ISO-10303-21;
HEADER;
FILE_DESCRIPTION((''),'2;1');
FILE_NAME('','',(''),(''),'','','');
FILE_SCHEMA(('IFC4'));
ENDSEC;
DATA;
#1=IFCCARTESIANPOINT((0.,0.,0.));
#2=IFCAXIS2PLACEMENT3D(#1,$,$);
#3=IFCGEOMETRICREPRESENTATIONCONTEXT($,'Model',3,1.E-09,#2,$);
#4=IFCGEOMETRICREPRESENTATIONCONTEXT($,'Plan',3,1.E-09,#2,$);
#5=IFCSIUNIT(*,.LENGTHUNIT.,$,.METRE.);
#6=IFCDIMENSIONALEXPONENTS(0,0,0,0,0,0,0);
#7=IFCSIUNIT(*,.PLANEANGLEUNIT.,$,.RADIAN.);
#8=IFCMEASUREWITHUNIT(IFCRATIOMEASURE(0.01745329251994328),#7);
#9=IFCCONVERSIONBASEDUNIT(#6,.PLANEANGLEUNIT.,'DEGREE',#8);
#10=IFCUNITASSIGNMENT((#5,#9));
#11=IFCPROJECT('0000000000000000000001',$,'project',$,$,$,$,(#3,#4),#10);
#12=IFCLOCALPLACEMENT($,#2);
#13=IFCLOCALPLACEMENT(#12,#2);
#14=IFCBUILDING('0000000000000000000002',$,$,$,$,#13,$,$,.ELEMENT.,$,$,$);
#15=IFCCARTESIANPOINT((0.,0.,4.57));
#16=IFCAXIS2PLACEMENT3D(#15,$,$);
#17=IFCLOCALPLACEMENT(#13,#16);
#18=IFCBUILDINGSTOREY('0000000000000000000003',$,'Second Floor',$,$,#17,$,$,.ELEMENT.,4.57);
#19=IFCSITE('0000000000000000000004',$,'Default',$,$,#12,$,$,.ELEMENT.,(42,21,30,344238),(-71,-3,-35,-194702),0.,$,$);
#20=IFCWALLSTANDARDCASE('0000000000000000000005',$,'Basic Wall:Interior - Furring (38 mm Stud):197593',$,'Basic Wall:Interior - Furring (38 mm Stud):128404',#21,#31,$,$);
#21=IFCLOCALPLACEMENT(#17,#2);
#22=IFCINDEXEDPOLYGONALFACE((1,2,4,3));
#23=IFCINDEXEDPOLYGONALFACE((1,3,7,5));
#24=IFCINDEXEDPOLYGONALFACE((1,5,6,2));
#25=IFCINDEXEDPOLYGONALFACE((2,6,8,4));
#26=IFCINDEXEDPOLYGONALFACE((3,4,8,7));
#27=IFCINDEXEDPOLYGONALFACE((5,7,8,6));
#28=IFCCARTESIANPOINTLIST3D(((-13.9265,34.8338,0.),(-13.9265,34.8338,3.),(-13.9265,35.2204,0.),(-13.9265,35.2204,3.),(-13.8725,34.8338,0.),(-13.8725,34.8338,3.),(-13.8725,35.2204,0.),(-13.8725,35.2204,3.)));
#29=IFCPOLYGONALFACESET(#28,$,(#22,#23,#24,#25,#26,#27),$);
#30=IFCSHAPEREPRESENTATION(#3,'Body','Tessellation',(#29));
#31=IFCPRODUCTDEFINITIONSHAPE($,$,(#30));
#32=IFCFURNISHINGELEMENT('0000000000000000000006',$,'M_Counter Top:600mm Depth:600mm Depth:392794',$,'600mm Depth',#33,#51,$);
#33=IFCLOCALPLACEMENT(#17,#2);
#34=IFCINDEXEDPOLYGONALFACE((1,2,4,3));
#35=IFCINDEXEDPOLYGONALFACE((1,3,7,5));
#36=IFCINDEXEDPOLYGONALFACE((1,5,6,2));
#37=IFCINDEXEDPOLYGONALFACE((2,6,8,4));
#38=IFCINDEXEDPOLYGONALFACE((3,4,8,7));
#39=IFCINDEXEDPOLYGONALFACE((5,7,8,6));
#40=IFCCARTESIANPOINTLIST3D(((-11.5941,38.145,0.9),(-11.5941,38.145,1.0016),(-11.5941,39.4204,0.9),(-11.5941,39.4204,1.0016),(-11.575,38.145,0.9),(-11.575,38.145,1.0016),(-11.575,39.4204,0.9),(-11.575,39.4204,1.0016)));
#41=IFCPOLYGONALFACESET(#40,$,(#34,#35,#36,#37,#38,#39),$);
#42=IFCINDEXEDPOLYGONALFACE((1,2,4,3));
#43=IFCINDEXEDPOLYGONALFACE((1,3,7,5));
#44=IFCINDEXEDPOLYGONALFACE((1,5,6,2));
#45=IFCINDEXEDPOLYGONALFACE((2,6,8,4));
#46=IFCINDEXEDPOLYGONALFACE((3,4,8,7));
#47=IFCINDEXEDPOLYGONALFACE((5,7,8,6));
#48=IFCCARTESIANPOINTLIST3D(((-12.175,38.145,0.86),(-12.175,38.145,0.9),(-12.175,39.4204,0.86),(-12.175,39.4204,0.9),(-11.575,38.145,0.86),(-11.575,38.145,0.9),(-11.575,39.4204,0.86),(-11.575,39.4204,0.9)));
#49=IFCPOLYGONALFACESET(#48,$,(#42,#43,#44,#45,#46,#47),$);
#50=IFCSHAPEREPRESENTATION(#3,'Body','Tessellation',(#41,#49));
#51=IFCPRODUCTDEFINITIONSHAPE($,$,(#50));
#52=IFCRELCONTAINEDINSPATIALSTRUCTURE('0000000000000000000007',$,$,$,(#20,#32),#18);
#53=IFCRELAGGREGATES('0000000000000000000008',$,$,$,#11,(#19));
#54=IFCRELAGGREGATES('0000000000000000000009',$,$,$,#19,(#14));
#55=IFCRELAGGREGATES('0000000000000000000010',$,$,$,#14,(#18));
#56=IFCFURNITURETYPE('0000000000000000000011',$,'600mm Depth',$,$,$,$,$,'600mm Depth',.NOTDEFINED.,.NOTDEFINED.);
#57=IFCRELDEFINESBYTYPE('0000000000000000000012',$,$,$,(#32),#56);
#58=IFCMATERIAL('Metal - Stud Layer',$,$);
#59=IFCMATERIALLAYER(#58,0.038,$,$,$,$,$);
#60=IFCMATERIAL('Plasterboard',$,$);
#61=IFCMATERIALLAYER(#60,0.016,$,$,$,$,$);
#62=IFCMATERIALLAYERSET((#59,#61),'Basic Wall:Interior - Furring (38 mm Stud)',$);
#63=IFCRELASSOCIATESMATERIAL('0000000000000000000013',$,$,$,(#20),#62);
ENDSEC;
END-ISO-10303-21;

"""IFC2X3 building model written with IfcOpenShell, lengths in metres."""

from ifc_helpers import new_model, entity, si_unit, converted_unit, frame, frame_2d, origin, origin_2d_with_axis, place, context, project, spatial, rectangle, extrude, source, transform, mapped, material, layer, layer_set, layer_usage, type_object, type_shapes, element, save


model = new_model("IFC2X3")

# Units and contexts
model_context = context("Model", 3, precision=1e-09, world=origin())
plan_context = context("Plan", 3, precision=1e-09, world=origin())
ifc_project = project(units=[si_unit("LENGTHUNIT", "METRE"), converted_unit("PLANEANGLEUNIT", "DEGREE", entity("IfcRatioMeasure", 0.01745329251994328), si_unit("PLANEANGLEUNIT", "RADIAN"), dimensions=[0, 0, 0, 0, 0, 0, 0])], contexts=[model_context, plan_context])

# Site, building, storey
site_placement = place(None, origin())
site = spatial("IfcSite", under=ifc_project, at=site_placement, Name="Default", CompositionType="ELEMENT", RefLatitude=(42, 21, 30, 344238), RefLongitude=(-71, -3, -35, -194702), RefElevation=0.0)
building_placement = place(site_placement, origin())
building = spatial("IfcBuilding", under=site, at=building_placement, CompositionType="ELEMENT")
storey_placement = place(building_placement, frame((0.0, 0.0, 4.57)))
storey = spatial("IfcBuildingStorey", under=building, at=storey_placement, Name="Second Floor", CompositionType="ELEMENT", Elevation=4.57)

# Shared definitions
ifc_material_1 = material(Name="Plasterboard")
ifc_material_2 = material(Name="Metal - Stud Layer")

# Wall
ifc_layer_1 = layer(ifc_material_2, 0.038)
ifc_layer_2 = layer(ifc_material_1, 0.016)
ifc_layer_set_1 = layer_set([ifc_layer_1, ifc_layer_2], Name="Basic Wall:Interior - Furring (38 mm Stud)")
ifc_layer_usage_1 = layer_usage(ifc_layer_set_1, "AXIS2", "POSITIVE", -0.027)
wall_1_placement = place(storey_placement, frame((-13.8995, 35.2204, 0.0), z_axis=(0.0, 0.0, 1.0), x_axis=(0.0, -1.0, 0.0)))
element("IfcWallStandardCase", 1, at=wall_1_placement, inside=storey, material=ifc_layer_usage_1, Name="Basic Wall:Interior - Furring (38 mm Stud):197593", ObjectType="Basic Wall:Interior - Furring (38 mm Stud):128404", context=model_context, shape_type="SweptSolid", body=[
    extrude(rectangle(XDim=0.3866, YDim=0.054, at=frame_2d((0.1933, 0.0), x_axis=(-1.0, 0.0))), origin(), (0.0, 0.0, 1.0), 3.0),
])

# Furnishing element
furniture_type = type_object("IfcFurnitureType", Name="600mm Depth", ElementType="600mm Depth", AssemblyPlace="NOTDEFINED")
shared_shape_1 = source(origin(), model_context, "Body", "SweptSolid", [
    extrude(rectangle(XDim=0.0191, YDim=1.2755, at=origin_2d_with_axis()), frame((-0.5627, -0.0095, 0.9), z_axis=(0.0, 0.0, 1.0), x_axis=(0.0, -1.0, 0.0)), (0.0, 0.0, 1.0), 0.1016),
    extrude(rectangle(XDim=1.2755, YDim=0.6, at=origin_2d_with_axis()), frame((-0.5627, -0.3, 0.86), z_axis=(0.0, 0.0, 1.0), x_axis=(-1.0, 0.0, 0.0)), (0.0, 0.0, 1.0), 0.04),
])
type_shapes(furniture_type, [shared_shape_1])
furnishing_placement = place(storey_placement, frame((-11.575, 38.22, 0.0), z_axis=(0.0, 0.0, 1.0), x_axis=(0.0, -1.0, 0.0)))
element("IfcFurnishingElement", 2, at=furnishing_placement, inside=storey, type_object=furniture_type, Name="M_Counter Top:600mm Depth:600mm Depth:392794", ObjectType="600mm Depth", context=model_context, shape_type="MappedRepresentation", body=[
    mapped(shared_shape_1, transform((0.0, 0.0, 0.0), scale=1.0)),
])

save(model, "model.ifc")
